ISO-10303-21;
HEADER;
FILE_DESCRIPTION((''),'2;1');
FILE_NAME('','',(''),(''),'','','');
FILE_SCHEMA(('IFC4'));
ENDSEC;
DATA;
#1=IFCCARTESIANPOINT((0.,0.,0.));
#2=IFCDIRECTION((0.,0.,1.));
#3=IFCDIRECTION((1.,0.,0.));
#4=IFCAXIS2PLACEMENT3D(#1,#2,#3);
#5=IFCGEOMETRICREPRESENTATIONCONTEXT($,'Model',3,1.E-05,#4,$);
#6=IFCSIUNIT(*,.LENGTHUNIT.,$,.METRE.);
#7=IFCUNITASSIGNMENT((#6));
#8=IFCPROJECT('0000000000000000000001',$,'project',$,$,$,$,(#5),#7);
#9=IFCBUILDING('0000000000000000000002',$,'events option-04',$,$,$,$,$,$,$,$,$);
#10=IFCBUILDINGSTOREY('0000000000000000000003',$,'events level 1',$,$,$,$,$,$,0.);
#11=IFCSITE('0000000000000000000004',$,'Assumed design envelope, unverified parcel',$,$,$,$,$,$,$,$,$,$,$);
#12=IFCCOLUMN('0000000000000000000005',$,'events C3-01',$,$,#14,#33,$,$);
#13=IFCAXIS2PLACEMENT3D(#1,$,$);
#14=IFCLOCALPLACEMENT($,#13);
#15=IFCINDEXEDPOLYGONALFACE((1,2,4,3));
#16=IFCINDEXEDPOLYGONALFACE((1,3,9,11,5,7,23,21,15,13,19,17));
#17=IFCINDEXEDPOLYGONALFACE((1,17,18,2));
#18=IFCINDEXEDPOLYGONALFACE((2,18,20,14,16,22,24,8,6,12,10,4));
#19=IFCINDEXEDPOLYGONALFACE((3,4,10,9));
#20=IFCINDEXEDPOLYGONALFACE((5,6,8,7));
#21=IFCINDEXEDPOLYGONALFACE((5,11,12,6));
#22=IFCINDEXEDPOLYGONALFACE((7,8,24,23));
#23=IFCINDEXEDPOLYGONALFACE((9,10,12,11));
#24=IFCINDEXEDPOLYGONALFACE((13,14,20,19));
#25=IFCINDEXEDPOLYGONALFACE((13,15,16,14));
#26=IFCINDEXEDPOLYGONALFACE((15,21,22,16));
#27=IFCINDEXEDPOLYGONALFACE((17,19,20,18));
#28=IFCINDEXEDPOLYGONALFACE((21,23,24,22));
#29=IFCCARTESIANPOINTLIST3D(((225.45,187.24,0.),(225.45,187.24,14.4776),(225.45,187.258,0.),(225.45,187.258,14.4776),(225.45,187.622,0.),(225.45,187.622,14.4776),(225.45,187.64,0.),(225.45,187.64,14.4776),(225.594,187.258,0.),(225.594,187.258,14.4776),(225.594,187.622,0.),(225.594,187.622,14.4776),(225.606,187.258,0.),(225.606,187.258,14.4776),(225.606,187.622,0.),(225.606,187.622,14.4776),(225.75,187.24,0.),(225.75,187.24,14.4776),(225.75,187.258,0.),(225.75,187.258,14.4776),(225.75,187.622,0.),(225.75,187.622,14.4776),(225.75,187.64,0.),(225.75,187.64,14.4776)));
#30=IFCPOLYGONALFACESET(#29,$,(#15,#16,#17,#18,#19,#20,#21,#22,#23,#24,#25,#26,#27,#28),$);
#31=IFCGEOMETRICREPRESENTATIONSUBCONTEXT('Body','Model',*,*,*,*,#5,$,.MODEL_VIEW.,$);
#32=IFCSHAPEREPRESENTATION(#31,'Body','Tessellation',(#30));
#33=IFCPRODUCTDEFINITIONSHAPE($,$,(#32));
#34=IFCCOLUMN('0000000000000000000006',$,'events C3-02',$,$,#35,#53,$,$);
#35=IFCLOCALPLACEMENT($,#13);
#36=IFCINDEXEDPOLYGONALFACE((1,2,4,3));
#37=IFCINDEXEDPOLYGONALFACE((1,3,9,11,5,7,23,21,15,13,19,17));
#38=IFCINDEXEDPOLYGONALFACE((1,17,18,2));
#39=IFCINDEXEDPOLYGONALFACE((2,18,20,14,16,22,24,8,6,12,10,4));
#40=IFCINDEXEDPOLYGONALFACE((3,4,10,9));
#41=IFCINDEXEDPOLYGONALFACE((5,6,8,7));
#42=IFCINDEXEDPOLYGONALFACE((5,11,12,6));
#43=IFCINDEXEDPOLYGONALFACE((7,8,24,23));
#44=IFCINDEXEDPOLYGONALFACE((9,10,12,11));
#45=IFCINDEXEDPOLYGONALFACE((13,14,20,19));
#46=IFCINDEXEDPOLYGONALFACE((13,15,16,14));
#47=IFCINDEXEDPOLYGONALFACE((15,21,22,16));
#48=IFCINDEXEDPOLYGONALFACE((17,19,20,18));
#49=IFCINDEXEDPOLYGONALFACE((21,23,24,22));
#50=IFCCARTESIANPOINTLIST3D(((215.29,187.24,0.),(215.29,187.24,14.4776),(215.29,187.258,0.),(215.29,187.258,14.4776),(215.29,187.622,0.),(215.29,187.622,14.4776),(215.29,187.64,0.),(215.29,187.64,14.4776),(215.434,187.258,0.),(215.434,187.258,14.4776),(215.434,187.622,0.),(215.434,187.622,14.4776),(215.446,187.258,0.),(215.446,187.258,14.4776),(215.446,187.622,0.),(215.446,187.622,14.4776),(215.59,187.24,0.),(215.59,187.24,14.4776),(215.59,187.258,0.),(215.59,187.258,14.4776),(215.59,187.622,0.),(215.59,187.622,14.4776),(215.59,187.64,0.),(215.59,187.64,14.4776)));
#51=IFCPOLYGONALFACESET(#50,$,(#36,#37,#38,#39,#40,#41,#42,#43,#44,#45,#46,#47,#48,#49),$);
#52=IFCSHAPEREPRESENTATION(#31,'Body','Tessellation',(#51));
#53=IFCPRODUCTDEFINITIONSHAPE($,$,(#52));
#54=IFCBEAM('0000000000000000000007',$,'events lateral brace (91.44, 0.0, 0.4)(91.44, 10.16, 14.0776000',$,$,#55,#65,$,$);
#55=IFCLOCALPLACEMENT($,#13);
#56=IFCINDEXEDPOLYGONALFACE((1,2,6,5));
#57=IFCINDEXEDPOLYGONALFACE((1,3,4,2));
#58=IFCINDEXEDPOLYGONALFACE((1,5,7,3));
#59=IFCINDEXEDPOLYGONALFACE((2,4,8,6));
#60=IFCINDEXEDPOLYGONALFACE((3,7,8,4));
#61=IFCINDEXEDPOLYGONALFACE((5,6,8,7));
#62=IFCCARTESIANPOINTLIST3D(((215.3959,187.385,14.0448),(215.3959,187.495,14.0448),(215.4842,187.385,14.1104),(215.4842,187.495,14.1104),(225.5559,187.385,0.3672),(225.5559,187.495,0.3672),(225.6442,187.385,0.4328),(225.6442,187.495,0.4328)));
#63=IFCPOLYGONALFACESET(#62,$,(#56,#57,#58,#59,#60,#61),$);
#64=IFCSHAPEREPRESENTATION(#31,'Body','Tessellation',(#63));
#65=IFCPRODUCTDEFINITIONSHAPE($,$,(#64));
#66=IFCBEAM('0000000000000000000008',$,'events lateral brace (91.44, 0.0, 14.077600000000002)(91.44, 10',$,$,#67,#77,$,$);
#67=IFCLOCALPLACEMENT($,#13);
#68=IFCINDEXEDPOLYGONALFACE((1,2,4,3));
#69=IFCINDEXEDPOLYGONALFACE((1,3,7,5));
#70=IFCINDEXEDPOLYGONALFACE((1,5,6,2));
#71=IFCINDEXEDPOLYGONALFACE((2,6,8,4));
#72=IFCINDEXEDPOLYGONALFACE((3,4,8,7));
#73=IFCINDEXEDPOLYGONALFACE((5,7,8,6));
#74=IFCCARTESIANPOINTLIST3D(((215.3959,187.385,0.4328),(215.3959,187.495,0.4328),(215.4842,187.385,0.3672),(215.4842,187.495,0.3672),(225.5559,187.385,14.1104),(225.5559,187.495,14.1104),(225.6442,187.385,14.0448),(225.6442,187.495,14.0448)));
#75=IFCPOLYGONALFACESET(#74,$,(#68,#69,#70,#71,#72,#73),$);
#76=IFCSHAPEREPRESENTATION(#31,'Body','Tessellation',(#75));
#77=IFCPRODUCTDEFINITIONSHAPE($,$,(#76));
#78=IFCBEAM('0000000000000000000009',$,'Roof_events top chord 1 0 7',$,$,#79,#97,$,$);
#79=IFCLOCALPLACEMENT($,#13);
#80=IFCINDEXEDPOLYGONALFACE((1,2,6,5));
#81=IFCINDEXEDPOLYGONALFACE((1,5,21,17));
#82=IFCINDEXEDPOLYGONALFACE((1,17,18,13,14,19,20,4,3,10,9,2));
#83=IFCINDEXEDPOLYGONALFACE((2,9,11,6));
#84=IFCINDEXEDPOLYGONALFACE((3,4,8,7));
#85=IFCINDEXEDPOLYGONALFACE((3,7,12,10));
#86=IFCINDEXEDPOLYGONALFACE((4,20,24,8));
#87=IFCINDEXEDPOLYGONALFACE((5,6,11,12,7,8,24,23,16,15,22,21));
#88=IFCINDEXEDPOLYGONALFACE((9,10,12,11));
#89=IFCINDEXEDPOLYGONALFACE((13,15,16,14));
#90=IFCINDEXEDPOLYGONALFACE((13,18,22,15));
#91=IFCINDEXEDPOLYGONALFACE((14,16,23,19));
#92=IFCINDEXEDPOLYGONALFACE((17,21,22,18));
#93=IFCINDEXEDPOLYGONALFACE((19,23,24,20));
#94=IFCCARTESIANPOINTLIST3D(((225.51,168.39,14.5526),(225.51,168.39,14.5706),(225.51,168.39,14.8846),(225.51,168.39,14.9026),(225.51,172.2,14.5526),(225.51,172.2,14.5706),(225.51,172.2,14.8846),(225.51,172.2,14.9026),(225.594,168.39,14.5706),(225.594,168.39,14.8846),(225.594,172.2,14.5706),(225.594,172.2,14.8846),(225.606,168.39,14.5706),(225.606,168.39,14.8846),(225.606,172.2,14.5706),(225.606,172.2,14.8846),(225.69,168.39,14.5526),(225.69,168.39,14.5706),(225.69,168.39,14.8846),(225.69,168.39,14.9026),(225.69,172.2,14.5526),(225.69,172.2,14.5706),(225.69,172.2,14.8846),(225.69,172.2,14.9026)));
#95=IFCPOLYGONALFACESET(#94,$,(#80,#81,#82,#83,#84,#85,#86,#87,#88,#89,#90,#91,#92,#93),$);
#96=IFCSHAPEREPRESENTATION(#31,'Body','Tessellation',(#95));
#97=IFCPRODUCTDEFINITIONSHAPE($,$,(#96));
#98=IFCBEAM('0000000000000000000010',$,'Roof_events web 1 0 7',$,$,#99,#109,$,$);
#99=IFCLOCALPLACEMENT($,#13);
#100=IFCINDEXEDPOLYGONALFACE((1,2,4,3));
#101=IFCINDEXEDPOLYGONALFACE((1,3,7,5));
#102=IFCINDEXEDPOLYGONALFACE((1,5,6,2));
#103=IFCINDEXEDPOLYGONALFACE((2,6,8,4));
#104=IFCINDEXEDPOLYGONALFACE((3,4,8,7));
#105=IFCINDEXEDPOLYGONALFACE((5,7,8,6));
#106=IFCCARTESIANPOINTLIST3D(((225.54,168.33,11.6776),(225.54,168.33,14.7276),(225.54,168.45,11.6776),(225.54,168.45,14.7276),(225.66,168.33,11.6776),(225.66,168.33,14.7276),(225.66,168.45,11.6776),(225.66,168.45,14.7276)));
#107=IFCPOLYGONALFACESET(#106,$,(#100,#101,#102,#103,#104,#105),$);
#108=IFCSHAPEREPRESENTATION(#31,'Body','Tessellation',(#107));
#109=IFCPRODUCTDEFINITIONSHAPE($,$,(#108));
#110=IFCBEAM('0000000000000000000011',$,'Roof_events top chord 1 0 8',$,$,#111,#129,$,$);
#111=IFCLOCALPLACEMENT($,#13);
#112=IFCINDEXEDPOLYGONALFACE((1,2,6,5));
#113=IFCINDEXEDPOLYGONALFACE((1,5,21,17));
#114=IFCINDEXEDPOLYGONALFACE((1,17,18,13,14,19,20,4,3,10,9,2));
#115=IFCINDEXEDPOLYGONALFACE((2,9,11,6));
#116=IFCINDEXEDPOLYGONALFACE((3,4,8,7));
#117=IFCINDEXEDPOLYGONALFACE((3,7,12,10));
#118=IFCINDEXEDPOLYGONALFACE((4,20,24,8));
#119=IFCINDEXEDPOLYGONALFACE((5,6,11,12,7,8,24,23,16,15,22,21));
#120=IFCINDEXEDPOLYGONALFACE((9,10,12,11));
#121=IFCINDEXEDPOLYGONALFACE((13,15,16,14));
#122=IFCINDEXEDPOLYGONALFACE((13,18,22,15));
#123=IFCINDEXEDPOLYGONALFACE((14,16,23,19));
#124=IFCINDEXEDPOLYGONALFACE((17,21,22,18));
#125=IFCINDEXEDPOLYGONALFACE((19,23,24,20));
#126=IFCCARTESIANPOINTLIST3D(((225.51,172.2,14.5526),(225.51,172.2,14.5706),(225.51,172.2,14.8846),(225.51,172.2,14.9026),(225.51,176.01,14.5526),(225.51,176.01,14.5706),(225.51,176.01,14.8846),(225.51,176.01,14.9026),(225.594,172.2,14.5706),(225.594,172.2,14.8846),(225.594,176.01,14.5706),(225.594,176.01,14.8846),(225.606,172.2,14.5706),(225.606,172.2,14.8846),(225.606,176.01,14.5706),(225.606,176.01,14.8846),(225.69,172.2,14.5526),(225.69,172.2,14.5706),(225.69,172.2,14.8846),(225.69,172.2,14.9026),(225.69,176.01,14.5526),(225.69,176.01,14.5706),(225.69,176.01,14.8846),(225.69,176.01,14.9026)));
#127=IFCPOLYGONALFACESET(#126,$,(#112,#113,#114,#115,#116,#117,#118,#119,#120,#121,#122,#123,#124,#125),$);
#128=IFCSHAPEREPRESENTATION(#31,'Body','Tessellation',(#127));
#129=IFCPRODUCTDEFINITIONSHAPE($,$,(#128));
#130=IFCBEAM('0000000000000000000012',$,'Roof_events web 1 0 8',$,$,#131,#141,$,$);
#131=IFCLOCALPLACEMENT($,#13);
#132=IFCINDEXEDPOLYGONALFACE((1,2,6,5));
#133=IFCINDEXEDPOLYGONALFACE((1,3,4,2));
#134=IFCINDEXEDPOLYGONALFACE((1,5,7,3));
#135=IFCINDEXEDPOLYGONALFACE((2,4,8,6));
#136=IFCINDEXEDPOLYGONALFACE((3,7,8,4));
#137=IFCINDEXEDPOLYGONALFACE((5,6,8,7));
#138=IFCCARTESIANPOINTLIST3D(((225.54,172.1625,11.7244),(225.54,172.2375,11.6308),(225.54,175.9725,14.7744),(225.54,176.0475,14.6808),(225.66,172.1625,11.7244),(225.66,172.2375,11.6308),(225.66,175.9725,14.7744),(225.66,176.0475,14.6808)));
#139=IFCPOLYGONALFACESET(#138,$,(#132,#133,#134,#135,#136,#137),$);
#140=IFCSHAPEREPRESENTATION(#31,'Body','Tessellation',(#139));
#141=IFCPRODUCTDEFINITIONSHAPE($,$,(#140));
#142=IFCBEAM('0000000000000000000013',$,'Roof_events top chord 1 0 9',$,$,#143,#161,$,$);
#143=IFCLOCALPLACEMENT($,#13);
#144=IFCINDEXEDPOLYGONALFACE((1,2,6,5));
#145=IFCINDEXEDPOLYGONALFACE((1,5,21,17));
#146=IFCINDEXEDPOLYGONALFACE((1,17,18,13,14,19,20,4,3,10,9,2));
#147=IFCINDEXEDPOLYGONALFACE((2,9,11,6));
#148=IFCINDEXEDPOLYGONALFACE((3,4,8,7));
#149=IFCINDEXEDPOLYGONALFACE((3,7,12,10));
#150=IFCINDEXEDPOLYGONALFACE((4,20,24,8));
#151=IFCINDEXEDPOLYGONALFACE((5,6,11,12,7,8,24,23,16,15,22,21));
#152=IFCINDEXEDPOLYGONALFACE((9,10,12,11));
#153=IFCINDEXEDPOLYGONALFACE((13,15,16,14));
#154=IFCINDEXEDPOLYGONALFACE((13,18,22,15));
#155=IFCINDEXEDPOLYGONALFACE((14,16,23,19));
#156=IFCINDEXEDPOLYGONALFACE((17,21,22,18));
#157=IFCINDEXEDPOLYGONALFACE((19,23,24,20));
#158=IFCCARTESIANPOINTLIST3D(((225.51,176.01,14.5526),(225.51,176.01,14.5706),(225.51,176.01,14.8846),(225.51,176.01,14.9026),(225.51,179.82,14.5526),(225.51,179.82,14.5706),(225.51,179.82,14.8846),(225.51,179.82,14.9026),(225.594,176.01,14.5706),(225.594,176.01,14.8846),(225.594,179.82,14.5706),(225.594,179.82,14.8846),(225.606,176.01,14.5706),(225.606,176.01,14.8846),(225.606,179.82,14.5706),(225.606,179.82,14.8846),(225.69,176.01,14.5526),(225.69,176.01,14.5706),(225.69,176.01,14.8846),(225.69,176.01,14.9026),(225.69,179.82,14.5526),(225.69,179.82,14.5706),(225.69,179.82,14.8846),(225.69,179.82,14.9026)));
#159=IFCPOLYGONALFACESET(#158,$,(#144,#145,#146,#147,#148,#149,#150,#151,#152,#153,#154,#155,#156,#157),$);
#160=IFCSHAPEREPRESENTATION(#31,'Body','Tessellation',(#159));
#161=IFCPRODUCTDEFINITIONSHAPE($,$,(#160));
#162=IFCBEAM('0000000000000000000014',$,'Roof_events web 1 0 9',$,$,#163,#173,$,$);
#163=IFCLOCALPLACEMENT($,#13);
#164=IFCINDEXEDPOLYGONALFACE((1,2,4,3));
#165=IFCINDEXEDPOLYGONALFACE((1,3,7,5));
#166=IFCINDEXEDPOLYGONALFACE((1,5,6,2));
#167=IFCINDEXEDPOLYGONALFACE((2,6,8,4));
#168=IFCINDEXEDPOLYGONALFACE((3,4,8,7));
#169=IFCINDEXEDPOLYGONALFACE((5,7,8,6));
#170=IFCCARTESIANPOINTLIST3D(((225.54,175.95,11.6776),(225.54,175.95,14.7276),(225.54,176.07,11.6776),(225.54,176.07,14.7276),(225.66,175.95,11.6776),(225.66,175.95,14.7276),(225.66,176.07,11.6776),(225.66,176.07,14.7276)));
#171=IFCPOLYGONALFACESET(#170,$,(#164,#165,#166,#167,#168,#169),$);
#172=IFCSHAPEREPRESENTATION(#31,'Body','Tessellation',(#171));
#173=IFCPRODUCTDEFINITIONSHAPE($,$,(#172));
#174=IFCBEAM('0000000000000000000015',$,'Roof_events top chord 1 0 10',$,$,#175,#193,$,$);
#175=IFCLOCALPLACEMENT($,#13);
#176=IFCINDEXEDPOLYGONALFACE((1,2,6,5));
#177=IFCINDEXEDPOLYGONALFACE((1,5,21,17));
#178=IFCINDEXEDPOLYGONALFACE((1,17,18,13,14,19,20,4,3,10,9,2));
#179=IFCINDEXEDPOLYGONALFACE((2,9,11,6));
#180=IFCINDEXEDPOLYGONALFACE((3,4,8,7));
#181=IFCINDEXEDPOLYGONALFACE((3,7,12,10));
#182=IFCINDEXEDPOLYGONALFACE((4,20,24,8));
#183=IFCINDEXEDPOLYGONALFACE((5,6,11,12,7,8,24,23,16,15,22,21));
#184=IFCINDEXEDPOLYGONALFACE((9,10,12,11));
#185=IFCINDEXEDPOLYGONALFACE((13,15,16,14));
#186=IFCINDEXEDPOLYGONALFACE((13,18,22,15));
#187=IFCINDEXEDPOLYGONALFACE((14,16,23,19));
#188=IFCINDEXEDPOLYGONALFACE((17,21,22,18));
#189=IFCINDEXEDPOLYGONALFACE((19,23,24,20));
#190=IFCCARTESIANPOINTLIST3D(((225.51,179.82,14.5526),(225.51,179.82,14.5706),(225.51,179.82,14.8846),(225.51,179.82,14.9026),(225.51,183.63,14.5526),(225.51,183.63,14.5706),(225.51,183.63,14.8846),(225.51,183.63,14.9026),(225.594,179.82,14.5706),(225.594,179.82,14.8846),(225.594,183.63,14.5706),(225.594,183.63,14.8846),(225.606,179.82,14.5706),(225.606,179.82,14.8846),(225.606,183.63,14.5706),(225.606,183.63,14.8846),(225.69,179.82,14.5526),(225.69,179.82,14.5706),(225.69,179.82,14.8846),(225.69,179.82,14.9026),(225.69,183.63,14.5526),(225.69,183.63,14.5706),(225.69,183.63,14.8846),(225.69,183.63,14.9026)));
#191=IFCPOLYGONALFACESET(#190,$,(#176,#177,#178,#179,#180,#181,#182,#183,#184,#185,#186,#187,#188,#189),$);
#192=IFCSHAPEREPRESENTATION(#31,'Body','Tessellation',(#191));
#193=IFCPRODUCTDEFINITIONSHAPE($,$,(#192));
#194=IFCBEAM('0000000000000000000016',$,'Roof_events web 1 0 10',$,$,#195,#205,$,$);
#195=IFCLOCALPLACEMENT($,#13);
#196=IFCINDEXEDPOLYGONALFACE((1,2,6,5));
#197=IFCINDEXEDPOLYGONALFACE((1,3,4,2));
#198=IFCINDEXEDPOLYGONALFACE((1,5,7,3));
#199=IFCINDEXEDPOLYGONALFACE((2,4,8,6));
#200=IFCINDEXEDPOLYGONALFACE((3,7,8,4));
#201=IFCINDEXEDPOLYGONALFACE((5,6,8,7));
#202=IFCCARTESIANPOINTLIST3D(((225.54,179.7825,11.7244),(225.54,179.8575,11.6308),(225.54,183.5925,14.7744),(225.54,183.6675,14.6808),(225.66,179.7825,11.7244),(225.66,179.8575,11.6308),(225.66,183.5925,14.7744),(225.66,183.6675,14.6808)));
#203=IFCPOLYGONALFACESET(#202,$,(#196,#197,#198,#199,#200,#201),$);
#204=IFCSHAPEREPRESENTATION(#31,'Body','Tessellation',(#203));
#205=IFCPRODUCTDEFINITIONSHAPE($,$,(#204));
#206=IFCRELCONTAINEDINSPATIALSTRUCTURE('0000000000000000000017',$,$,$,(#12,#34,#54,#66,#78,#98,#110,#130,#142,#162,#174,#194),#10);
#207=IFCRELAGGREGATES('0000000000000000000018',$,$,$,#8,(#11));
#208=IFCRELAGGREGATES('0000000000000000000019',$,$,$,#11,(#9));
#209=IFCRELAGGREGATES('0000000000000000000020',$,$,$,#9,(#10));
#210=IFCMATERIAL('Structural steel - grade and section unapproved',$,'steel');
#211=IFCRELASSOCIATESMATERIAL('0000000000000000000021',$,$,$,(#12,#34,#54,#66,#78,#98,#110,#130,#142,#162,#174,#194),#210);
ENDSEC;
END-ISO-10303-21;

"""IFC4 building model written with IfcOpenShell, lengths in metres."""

from ifc_helpers import new_model, si_unit, frame, origin_with_axes, place, context, subcontext, project, spatial, rectangle, i_section, extrude, material, element, save


model = new_model("IFC4")

# Units and contexts
model_context = context("Model", 3, precision=1e-05, world=origin_with_axes())
body_context = subcontext(model_context, "Body", "Model", "MODEL_VIEW")
ifc_project = project(units=[si_unit("LENGTHUNIT", "METRE")], contexts=[model_context])

# Site, building, storey
site = spatial("IfcSite", under=ifc_project, Name="Assumed design envelope, unverified parcel")
building = spatial("IfcBuilding", under=site, Name="events option-04")
storey = spatial("IfcBuildingStorey", under=building, Name="events level 1", Elevation=0.0)

# Columns
ifc_material_1 = material(Name="Structural steel - grade and section unapproved", Category="steel")
for number, where, z_axis, x_axis, name in (
    (1, (225.6, 187.44, 0.0), (0.0, 0.0, 1.0), (-1.0, 0.0, 0.0), "events C3-01"),
    (2, (215.44, 187.44, 0.0), (0.0, 0.0, 1.0), (-1.0, 0.0, 0.0), "events C3-02"),
):
    element("IfcColumn", number, at=place(None, frame(where, z_axis=z_axis, x_axis=x_axis)), inside=storey, material=ifc_material_1, Name=name, context=body_context, shape_type="SweptSolid", body=[
        extrude(i_section(OverallWidth=0.3, OverallDepth=0.4, WebThickness=0.012, FlangeThickness=0.018, FilletRadius=0.0), origin_with_axes(), (0.0, 0.0, 1.0), 14.4776),
    ])

# Beams
for number, where, z_axis, x_axis, name in (
    (3, (225.6, 187.44, 0.4), (-0.596305, 0.0, 0.802758), (0.0, -1.0, 0.0), "events lateral brace (91.44, 0.0, 0.4)(91.44, 10.16, 14.0776000"),
    (4, (225.6, 187.44, 14.0776), (-0.596305, 0.0, -0.802758), (0.0, -1.0, 0.0), "events lateral brace (91.44, 0.0, 14.077600000000002)(91.44, 10"),
):
    element("IfcBeam", number, at=place(None, frame(where, z_axis=z_axis, x_axis=x_axis)), inside=storey, material=ifc_material_1, Name=name, context=body_context, shape_type="SweptSolid", body=[
        extrude(rectangle(XDim=0.11, YDim=0.11), origin_with_axes(), (0.0, 0.0, 1.0), 17.0383),
    ])
beam_1_placement = place(None, frame((225.6, 168.39, 14.7276), z_axis=(0.0, 1.0, 0.0), x_axis=(-1.0, 0.0, 0.0)))
element("IfcBeam", 5, at=beam_1_placement, inside=storey, material=ifc_material_1, Name="Roof_events top chord 1 0 7", context=body_context, shape_type="SweptSolid", body=[
    extrude(i_section(OverallWidth=0.18, OverallDepth=0.35, WebThickness=0.012, FlangeThickness=0.018, FilletRadius=0.0), origin_with_axes(), (0.0, 0.0, 1.0), 3.81),
])
beam_2_placement = place(None, frame((225.6, 168.39, 11.6776), z_axis=(0.0, 0.0, 1.0), x_axis=(-1.0, 0.0, 0.0)))
element("IfcBeam", 6, at=beam_2_placement, inside=storey, material=ifc_material_1, Name="Roof_events web 1 0 7", context=body_context, shape_type="SweptSolid", body=[
    extrude(rectangle(XDim=0.12, YDim=0.12), origin_with_axes(), (0.0, 0.0, 1.0), 3.05),
])
beam_3_placement = place(None, frame((225.6, 172.2, 14.7276), z_axis=(0.0, 1.0, 0.0), x_axis=(-1.0, 0.0, 0.0)))
element("IfcBeam", 7, at=beam_3_placement, inside=storey, material=ifc_material_1, Name="Roof_events top chord 1 0 8", context=body_context, shape_type="SweptSolid", body=[
    extrude(i_section(OverallWidth=0.18, OverallDepth=0.35, WebThickness=0.012, FlangeThickness=0.018, FilletRadius=0.0), origin_with_axes(), (0.0, 0.0, 1.0), 3.81),
])
beam_4_placement = place(None, frame((225.6, 172.2, 11.6776), z_axis=(0.0, 0.780669, 0.624945), x_axis=(-1.0, 0.0, 0.0)))
element("IfcBeam", 8, at=beam_4_placement, inside=storey, material=ifc_material_1, Name="Roof_events web 1 0 8", context=body_context, shape_type="SweptSolid", body=[
    extrude(rectangle(XDim=0.12, YDim=0.12), origin_with_axes(), (0.0, 0.0, 1.0), 4.8804),
])
beam_5_placement = place(None, frame((225.6, 176.01, 14.7276), z_axis=(0.0, 1.0, 0.0), x_axis=(-1.0, 0.0, 0.0)))
element("IfcBeam", 9, at=beam_5_placement, inside=storey, material=ifc_material_1, Name="Roof_events top chord 1 0 9", context=body_context, shape_type="SweptSolid", body=[
    extrude(i_section(OverallWidth=0.18, OverallDepth=0.35, WebThickness=0.012, FlangeThickness=0.018, FilletRadius=0.0), origin_with_axes(), (0.0, 0.0, 1.0), 3.81),
])
beam_6_placement = place(None, frame((225.6, 176.01, 11.6776), z_axis=(0.0, 0.0, 1.0), x_axis=(-1.0, 0.0, 0.0)))
element("IfcBeam", 10, at=beam_6_placement, inside=storey, material=ifc_material_1, Name="Roof_events web 1 0 9", context=body_context, shape_type="SweptSolid", body=[
    extrude(rectangle(XDim=0.12, YDim=0.12), origin_with_axes(), (0.0, 0.0, 1.0), 3.05),
])
beam_7_placement = place(None, frame((225.6, 179.82, 14.7276), z_axis=(0.0, 1.0, 0.0), x_axis=(-1.0, 0.0, 0.0)))
element("IfcBeam", 11, at=beam_7_placement, inside=storey, material=ifc_material_1, Name="Roof_events top chord 1 0 10", context=body_context, shape_type="SweptSolid", body=[
    extrude(i_section(OverallWidth=0.18, OverallDepth=0.35, WebThickness=0.012, FlangeThickness=0.018, FilletRadius=0.0), origin_with_axes(), (0.0, 0.0, 1.0), 3.81),
])
beam_8_placement = place(None, frame((225.6, 179.82, 11.6776), z_axis=(0.0, 0.780669, 0.624945), x_axis=(-1.0, 0.0, 0.0)))
element("IfcBeam", 12, at=beam_8_placement, inside=storey, material=ifc_material_1, Name="Roof_events web 1 0 10", context=body_context, shape_type="SweptSolid", body=[
    extrude(rectangle(XDim=0.12, YDim=0.12), origin_with_axes(), (0.0, 0.0, 1.0), 4.8804),
])

save(model, "model.ifc")
